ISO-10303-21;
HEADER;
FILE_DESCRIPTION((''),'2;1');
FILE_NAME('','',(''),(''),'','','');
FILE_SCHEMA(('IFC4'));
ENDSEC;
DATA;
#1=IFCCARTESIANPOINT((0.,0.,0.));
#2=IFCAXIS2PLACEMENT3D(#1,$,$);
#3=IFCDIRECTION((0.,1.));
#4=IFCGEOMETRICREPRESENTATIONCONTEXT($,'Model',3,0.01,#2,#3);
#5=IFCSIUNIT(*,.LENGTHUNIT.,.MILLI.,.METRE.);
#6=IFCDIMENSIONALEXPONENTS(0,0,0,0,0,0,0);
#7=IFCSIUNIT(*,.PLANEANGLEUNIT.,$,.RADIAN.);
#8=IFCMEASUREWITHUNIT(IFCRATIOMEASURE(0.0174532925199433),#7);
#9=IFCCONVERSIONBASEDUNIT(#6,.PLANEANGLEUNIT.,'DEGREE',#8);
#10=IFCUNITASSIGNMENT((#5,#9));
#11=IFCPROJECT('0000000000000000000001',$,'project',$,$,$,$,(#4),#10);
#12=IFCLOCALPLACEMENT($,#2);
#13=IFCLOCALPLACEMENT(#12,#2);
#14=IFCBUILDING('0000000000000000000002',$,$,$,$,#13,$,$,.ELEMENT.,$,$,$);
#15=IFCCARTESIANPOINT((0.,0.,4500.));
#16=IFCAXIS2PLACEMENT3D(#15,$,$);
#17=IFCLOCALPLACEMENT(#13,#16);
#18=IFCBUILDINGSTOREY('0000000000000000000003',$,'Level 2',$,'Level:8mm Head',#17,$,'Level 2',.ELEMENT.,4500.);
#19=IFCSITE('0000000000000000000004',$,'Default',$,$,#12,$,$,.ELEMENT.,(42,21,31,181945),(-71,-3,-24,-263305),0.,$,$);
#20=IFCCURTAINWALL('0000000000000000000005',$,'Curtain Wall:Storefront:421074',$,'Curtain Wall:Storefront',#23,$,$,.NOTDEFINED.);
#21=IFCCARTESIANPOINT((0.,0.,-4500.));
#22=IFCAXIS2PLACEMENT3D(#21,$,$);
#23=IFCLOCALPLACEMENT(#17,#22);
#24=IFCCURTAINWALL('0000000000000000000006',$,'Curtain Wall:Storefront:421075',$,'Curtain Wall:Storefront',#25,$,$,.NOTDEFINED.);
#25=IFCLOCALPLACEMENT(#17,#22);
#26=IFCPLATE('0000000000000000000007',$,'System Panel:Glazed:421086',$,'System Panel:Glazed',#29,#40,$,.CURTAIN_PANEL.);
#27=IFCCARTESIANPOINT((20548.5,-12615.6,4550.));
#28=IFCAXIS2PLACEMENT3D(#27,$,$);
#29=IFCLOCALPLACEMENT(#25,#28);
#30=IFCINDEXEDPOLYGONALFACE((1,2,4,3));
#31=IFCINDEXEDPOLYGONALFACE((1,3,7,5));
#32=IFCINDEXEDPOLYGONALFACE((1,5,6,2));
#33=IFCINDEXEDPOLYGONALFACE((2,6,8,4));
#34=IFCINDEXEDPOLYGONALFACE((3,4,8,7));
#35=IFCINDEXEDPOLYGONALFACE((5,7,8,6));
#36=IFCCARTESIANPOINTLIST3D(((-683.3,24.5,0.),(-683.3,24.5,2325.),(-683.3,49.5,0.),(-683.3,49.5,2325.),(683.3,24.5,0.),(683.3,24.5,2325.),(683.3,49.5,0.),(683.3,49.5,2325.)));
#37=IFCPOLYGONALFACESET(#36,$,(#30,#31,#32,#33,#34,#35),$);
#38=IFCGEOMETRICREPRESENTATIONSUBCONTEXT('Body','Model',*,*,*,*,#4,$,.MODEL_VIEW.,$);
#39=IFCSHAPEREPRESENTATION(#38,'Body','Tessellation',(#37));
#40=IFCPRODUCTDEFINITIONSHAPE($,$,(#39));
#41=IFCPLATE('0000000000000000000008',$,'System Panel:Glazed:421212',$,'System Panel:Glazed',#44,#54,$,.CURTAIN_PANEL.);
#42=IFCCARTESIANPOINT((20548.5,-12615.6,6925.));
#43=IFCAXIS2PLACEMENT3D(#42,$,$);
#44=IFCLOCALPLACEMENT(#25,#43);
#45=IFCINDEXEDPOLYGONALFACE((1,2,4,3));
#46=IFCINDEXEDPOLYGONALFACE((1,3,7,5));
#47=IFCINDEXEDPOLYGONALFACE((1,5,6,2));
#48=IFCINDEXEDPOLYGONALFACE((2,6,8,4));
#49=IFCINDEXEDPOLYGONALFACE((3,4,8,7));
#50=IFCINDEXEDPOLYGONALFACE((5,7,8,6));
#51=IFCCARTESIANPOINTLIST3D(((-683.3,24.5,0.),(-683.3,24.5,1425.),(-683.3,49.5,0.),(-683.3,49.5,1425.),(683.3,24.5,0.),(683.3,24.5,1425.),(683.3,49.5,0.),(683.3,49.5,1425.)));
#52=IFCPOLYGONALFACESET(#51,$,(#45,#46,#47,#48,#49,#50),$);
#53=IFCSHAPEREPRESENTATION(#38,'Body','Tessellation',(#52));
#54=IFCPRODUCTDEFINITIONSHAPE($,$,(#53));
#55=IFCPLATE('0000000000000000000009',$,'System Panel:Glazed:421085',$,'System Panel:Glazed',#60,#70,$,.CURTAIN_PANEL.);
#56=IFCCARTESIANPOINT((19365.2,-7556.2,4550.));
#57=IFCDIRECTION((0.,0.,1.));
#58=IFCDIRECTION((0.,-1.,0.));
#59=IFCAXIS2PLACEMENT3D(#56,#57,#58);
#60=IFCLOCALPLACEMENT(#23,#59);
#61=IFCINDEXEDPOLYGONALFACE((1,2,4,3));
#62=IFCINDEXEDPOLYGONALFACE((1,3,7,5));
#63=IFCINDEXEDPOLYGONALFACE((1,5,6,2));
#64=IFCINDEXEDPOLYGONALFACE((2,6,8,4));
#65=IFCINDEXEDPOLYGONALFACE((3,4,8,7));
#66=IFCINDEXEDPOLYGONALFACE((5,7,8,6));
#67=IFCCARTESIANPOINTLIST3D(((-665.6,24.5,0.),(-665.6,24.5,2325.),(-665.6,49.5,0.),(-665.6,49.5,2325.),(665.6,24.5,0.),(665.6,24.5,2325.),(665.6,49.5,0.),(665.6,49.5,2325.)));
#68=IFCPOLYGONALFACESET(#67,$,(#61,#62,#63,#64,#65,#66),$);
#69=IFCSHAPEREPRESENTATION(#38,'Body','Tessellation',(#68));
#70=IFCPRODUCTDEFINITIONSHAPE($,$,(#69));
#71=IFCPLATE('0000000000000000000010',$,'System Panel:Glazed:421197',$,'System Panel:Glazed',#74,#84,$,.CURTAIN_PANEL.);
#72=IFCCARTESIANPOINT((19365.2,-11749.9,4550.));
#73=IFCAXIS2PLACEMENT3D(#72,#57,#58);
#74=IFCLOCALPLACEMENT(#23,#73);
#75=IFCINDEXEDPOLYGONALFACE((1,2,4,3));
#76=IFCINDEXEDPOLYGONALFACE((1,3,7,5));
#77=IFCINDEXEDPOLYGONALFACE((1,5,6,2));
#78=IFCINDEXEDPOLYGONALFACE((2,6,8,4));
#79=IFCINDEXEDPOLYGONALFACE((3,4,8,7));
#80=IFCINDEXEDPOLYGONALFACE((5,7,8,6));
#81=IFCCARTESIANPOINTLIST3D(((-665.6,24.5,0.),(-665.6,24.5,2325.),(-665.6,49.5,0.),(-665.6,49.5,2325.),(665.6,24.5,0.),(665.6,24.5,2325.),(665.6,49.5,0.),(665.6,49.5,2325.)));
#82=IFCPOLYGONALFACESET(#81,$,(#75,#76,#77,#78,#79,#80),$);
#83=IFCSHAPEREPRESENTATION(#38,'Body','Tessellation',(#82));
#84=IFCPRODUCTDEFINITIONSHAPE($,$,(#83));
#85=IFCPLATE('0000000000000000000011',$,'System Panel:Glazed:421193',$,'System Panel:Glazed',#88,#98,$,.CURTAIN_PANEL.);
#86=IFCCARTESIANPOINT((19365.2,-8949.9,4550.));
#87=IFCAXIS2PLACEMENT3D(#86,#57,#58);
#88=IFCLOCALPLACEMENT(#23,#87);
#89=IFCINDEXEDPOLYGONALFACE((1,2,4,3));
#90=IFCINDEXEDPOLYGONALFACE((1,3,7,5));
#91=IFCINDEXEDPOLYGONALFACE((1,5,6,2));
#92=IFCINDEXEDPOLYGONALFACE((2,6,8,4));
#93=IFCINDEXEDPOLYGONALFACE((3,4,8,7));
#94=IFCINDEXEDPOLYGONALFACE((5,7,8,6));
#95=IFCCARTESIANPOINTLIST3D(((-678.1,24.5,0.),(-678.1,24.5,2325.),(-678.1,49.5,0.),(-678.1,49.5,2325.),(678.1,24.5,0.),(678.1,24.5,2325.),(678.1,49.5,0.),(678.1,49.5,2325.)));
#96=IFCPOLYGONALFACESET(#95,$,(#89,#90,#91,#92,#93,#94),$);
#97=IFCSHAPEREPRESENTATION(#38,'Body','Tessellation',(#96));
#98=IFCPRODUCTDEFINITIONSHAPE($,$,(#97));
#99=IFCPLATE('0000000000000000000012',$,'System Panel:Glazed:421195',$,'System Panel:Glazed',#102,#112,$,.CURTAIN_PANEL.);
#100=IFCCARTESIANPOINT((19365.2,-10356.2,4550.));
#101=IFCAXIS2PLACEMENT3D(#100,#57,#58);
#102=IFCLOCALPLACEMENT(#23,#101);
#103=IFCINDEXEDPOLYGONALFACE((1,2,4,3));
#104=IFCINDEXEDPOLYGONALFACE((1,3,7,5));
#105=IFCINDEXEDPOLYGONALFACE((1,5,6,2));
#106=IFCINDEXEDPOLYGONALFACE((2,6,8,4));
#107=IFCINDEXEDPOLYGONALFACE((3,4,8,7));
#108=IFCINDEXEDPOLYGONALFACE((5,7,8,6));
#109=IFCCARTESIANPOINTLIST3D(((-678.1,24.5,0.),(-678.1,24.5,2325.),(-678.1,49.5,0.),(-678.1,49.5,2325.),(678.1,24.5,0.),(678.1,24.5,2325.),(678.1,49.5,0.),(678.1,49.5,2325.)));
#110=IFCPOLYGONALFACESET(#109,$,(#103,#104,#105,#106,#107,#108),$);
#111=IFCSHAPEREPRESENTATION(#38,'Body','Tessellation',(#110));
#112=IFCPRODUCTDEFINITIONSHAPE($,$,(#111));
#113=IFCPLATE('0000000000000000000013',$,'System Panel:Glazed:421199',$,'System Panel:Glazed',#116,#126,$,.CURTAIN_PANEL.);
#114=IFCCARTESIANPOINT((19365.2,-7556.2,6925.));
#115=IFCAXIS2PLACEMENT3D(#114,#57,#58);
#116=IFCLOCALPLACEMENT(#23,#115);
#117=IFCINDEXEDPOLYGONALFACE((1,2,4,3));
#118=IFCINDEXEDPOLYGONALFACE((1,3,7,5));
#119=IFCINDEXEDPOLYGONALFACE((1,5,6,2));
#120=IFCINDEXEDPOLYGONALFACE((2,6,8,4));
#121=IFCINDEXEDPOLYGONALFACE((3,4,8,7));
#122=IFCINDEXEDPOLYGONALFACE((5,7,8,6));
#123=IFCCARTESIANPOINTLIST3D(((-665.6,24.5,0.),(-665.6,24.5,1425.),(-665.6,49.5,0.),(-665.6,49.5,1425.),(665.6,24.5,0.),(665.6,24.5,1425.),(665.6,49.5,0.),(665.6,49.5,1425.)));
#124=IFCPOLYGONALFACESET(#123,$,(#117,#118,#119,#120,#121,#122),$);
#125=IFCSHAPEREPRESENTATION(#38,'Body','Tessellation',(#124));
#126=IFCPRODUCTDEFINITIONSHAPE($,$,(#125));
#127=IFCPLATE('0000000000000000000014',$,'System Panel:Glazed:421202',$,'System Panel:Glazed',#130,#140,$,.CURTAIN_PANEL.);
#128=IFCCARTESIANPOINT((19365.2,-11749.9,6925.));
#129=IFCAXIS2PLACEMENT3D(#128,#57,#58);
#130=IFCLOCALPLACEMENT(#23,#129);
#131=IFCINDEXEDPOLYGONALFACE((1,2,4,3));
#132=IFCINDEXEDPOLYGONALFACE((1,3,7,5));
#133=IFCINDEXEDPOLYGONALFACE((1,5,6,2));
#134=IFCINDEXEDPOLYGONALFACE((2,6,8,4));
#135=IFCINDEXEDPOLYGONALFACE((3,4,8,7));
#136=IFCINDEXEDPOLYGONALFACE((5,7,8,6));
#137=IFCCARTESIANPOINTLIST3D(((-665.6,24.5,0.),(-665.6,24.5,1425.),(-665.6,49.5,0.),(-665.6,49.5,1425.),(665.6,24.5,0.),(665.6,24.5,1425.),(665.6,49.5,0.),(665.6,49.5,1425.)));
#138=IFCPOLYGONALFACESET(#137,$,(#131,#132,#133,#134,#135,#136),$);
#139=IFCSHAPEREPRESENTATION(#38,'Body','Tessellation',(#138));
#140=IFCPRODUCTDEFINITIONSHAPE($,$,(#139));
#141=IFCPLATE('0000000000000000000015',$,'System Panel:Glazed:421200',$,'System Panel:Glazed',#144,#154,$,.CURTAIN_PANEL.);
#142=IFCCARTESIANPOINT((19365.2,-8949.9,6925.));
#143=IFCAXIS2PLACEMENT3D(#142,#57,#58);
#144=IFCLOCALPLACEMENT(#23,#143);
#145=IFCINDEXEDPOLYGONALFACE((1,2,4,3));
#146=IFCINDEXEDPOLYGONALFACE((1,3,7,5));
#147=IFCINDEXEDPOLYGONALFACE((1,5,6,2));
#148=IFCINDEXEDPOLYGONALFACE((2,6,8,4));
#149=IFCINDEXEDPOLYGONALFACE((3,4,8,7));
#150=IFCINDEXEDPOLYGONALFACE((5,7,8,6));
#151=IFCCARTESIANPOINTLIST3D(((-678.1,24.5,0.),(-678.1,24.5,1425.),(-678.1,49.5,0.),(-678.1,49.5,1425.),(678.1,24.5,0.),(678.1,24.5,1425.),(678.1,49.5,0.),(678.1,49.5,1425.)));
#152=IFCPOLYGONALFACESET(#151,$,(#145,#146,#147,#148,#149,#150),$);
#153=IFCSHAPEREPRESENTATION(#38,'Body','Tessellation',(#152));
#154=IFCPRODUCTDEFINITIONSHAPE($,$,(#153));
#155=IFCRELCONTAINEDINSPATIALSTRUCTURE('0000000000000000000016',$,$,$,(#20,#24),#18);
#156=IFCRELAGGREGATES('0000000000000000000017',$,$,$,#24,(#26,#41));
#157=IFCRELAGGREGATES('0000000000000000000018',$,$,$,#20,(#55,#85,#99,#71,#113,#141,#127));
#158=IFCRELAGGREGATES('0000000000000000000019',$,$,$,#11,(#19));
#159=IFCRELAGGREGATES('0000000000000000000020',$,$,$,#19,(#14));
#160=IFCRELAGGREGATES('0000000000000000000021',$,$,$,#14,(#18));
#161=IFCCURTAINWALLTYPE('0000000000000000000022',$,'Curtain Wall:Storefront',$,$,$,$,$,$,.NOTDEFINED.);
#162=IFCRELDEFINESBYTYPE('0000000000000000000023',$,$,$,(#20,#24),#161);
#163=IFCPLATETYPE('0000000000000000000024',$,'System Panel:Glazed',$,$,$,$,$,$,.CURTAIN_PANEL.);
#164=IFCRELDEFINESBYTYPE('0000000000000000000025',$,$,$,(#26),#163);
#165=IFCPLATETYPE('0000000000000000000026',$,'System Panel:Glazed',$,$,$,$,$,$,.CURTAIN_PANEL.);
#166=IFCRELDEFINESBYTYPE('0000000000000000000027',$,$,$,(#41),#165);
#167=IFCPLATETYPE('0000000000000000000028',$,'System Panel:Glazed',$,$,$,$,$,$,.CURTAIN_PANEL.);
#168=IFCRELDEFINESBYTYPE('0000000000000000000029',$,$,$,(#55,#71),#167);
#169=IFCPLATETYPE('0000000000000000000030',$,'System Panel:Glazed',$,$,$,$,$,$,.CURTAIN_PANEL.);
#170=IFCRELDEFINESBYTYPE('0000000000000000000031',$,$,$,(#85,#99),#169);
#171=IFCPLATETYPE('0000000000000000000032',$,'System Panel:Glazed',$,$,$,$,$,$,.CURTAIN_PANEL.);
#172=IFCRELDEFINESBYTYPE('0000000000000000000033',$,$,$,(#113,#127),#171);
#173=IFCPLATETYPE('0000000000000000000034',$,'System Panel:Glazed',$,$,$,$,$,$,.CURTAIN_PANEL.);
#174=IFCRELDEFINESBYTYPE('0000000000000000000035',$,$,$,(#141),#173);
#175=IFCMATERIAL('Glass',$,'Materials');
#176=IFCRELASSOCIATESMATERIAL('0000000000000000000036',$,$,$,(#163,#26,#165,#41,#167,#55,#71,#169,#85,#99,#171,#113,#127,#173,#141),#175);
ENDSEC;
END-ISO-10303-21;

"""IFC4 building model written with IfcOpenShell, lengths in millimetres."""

from ifc_helpers import new_model, entity, si_unit, converted_unit, direction, frame, origin, place, context, subcontext, project, spatial, indexed_curve, outline, extrude, shape, source, transform, mapped, material, type_object, type_shapes, element, aggregate, save


model = new_model("IFC4")

# Units and contexts
model_context = context("Model", 3, precision=0.01, world=origin(), true_north=direction((0.0, 1.0)))
body_context = subcontext(model_context, "Body", "Model", "MODEL_VIEW")
footprint_context = subcontext(model_context, "FootPrint", "Model", "MODEL_VIEW")
ifc_project = project(units=[si_unit("LENGTHUNIT", "METRE", prefix="MILLI"), converted_unit("PLANEANGLEUNIT", "DEGREE", entity("IfcRatioMeasure", 0.0174532925199433), si_unit("PLANEANGLEUNIT", "RADIAN"), dimensions=[0, 0, 0, 0, 0, 0, 0])], contexts=[model_context])

# Site, building, storey
site_placement = place(None, origin())
site = spatial("IfcSite", under=ifc_project, at=site_placement, Name="Default", CompositionType="ELEMENT", RefLatitude=(42, 21, 31, 181945), RefLongitude=(-71, -3, -24, -263305), RefElevation=0.0)
building_placement = place(site_placement, origin())
building = spatial("IfcBuilding", under=site, at=building_placement, CompositionType="ELEMENT")
storey_placement = place(building_placement, frame((0.0, 0.0, 4500.0)))
storey = spatial("IfcBuildingStorey", under=building, at=storey_placement, Name="Level 2", ObjectType="Level:8mm Head", LongName="Level 2", CompositionType="ELEMENT", Elevation=4500.0)

# Curtain wall
curtain_wall_type_1 = type_object("IfcCurtainWallType", Name="Curtain Wall:Storefront", PredefinedType="NOTDEFINED")
curtain_wall_1_placement = place(storey_placement, frame((0.0, 0.0, -4500.0)))
curtain_wall_1 = element("IfcCurtainWall", 1, at=curtain_wall_1_placement, inside=storey, type_object=curtain_wall_type_1, Name="Curtain Wall:Storefront:421074", ObjectType="Curtain Wall:Storefront", PredefinedType="NOTDEFINED")

# Curtain wall
curtain_wall_2_placement = place(storey_placement, frame((0.0, 0.0, -4500.0)))
curtain_wall_2 = element("IfcCurtainWall", 2, at=curtain_wall_2_placement, inside=storey, type_object=curtain_wall_type_1, Name="Curtain Wall:Storefront:421075", ObjectType="Curtain Wall:Storefront", PredefinedType="NOTDEFINED")

# Plates
ifc_material_1 = material(Name="Glass", Category="Materials")
plate_type_1 = type_object("IfcPlateType", Name="System Panel:Glazed", PredefinedType="CURTAIN_PANEL", material=ifc_material_1)
shared_shape_1 = source(origin(), body_context, "Body", "SweptSolid", [
    extrude(outline(indexed_curve([(-12.5, -683.3), (12.5, -683.3), (12.5, 683.3), (-12.5, 683.3), (-12.5, -683.3)], self_intersect=False)), frame((0.0, 37.0, 0.0), z_axis=(0.0, 0.0, 1.0), x_axis=(0.0, 1.0, 0.0)), (0.0, 0.0, 1.0), 2325.0),
])
shared_shape_2 = source(origin(), footprint_context, "FootPrint", "Curve2D", [
    entity("IfcIndexedPolyCurve", entity("IfcCartesianPointList2D", [[683.3, 24.5], [683.3, 49.5], [-683.3, 49.5], [-683.3, 24.5], [683.3, 24.5]]), None, False),
])
type_shapes(plate_type_1, [shared_shape_1, shared_shape_2])
plate_1_placement = place(curtain_wall_2_placement, frame((20548.5, -12615.6, 4550.0)))
plate_1 = element("IfcPlate", 3, at=plate_1_placement, type_object=plate_type_1, material=ifc_material_1, Name="System Panel:Glazed:421086", ObjectType="System Panel:Glazed", PredefinedType="CURTAIN_PANEL", shapes=[
    shape(body_context, "Body", "MappedRepresentation", [mapped(shared_shape_1, transform((0.0, 0.0, 0.0), scale=1.0))]),
    shape(body_context, "Body", "MappedRepresentation", [mapped(shared_shape_2, transform((0.0, 0.0, 0.0), scale=1.0))]),
])
plate_type_2 = type_object("IfcPlateType", Name="System Panel:Glazed", PredefinedType="CURTAIN_PANEL", material=ifc_material_1)
shared_shape_3 = source(origin(), body_context, "Body", "SweptSolid", [
    extrude(outline(indexed_curve([(-12.5, -683.3), (12.5, -683.3), (12.5, 683.3), (-12.5, 683.3), (-12.5, -683.3)], self_intersect=False)), frame((0.0, 37.0, 0.0), z_axis=(0.0, 0.0, 1.0), x_axis=(0.0, 1.0, 0.0)), (0.0, 0.0, 1.0), 1425.0),
])
shared_shape_4 = source(origin(), footprint_context, "FootPrint", "Curve2D", [
    entity("IfcIndexedPolyCurve", entity("IfcCartesianPointList2D", [[683.3, 24.5], [683.3, 49.5], [-683.3, 49.5], [-683.3, 24.5], [683.3, 24.5]]), None, False),
])
type_shapes(plate_type_2, [shared_shape_3, shared_shape_4])
plate_2_placement = place(curtain_wall_2_placement, frame((20548.5, -12615.6, 6925.0)))
plate_2 = element("IfcPlate", 4, at=plate_2_placement, type_object=plate_type_2, material=ifc_material_1, Name="System Panel:Glazed:421212", ObjectType="System Panel:Glazed", PredefinedType="CURTAIN_PANEL", shapes=[
    shape(body_context, "Body", "MappedRepresentation", [mapped(shared_shape_3, transform((0.0, 0.0, 0.0), scale=1.0))]),
    shape(body_context, "Body", "MappedRepresentation", [mapped(shared_shape_4, transform((0.0, 0.0, 0.0), scale=1.0))]),
])
aggregate(curtain_wall_2, [plate_1, plate_2])
plate_type_3 = type_object("IfcPlateType", Name="System Panel:Glazed", PredefinedType="CURTAIN_PANEL", material=ifc_material_1)
shared_shape_5 = source(origin(), body_context, "Body", "SweptSolid", [
    extrude(outline(indexed_curve([(-12.5, -665.6), (12.5, -665.6), (12.5, 665.6), (-12.5, 665.6), (-12.5, -665.6)], self_intersect=False)), frame((0.0, 37.0, 0.0), z_axis=(0.0, 0.0, 1.0), x_axis=(0.0, 1.0, 0.0)), (0.0, 0.0, 1.0), 2325.0),
])
shared_shape_6 = source(origin(), footprint_context, "FootPrint", "Curve2D", [
    entity("IfcIndexedPolyCurve", entity("IfcCartesianPointList2D", [[665.6, 24.5], [665.6, 49.5], [-665.6, 49.5], [-665.6, 24.5], [665.6, 24.5]]), None, False),
])
type_shapes(plate_type_3, [shared_shape_5, shared_shape_6])
plate_3_placement = place(curtain_wall_1_placement, frame((19365.2, -7556.2, 4550.0), z_axis=(0.0, 0.0, 1.0), x_axis=(0.0, -1.0, 0.0)))
plate_3 = element("IfcPlate", 5, at=plate_3_placement, type_object=plate_type_3, material=ifc_material_1, Name="System Panel:Glazed:421085", ObjectType="System Panel:Glazed", PredefinedType="CURTAIN_PANEL", shapes=[
    shape(body_context, "Body", "MappedRepresentation", [mapped(shared_shape_5, transform((0.0, 0.0, 0.0), scale=1.0))]),
    shape(body_context, "Body", "MappedRepresentation", [mapped(shared_shape_6, transform((0.0, 0.0, 0.0), scale=1.0))]),
])
plate_4_placement = place(curtain_wall_1_placement, frame((19365.2, -11749.9, 4550.0), z_axis=(0.0, 0.0, 1.0), x_axis=(0.0, -1.0, 0.0)))
plate_4 = element("IfcPlate", 6, at=plate_4_placement, type_object=plate_type_3, material=ifc_material_1, Name="System Panel:Glazed:421197", ObjectType="System Panel:Glazed", PredefinedType="CURTAIN_PANEL", shapes=[
    shape(body_context, "Body", "MappedRepresentation", [mapped(shared_shape_5, transform((0.0, 0.0, 0.0), scale=1.0))]),
    shape(body_context, "Body", "MappedRepresentation", [mapped(shared_shape_6, transform((0.0, 0.0, 0.0), scale=1.0))]),
])
plate_type_4 = type_object("IfcPlateType", Name="System Panel:Glazed", PredefinedType="CURTAIN_PANEL", material=ifc_material_1)
shared_shape_7 = source(origin(), body_context, "Body", "SweptSolid", [
    extrude(outline(indexed_curve([(-12.5, -678.1), (12.5, -678.1), (12.5, 678.1), (-12.5, 678.1), (-12.5, -678.1)], self_intersect=False)), frame((0.0, 37.0, 0.0), z_axis=(0.0, 0.0, 1.0), x_axis=(0.0, 1.0, 0.0)), (0.0, 0.0, 1.0), 2325.0),
])
shared_shape_8 = source(origin(), footprint_context, "FootPrint", "Curve2D", [
    entity("IfcIndexedPolyCurve", entity("IfcCartesianPointList2D", [[678.1, 24.5], [678.1, 49.5], [-678.1, 49.5], [-678.1, 24.5], [678.1, 24.5]]), None, False),
])
type_shapes(plate_type_4, [shared_shape_7, shared_shape_8])
plate_5_placement = place(curtain_wall_1_placement, frame((19365.2, -8949.9, 4550.0), z_axis=(0.0, 0.0, 1.0), x_axis=(0.0, -1.0, 0.0)))
plate_5 = element("IfcPlate", 7, at=plate_5_placement, type_object=plate_type_4, material=ifc_material_1, Name="System Panel:Glazed:421193", ObjectType="System Panel:Glazed", PredefinedType="CURTAIN_PANEL", shapes=[
    shape(body_context, "Body", "MappedRepresentation", [mapped(shared_shape_7, transform((0.0, 0.0, 0.0), scale=1.0))]),
    shape(body_context, "Body", "MappedRepresentation", [mapped(shared_shape_8, transform((0.0, 0.0, 0.0), scale=1.0))]),
])
plate_6_placement = place(curtain_wall_1_placement, frame((19365.2, -10356.2, 4550.0), z_axis=(0.0, 0.0, 1.0), x_axis=(0.0, -1.0, 0.0)))
plate_6 = element("IfcPlate", 8, at=plate_6_placement, type_object=plate_type_4, material=ifc_material_1, Name="System Panel:Glazed:421195", ObjectType="System Panel:Glazed", PredefinedType="CURTAIN_PANEL", shapes=[
    shape(body_context, "Body", "MappedRepresentation", [mapped(shared_shape_7, transform((0.0, 0.0, 0.0), scale=1.0))]),
    shape(body_context, "Body", "MappedRepresentation", [mapped(shared_shape_8, transform((0.0, 0.0, 0.0), scale=1.0))]),
])
plate_type_5 = type_object("IfcPlateType", Name="System Panel:Glazed", PredefinedType="CURTAIN_PANEL", material=ifc_material_1)
shared_shape_9 = source(origin(), body_context, "Body", "SweptSolid", [
    extrude(outline(indexed_curve([(-12.5, -665.6), (12.5, -665.6), (12.5, 665.6), (-12.5, 665.6), (-12.5, -665.6)], self_intersect=False)), frame((0.0, 37.0, 0.0), z_axis=(0.0, 0.0, 1.0), x_axis=(0.0, 1.0, 0.0)), (0.0, 0.0, 1.0), 1425.0),
])
shared_shape_10 = source(origin(), footprint_context, "FootPrint", "Curve2D", [
    entity("IfcIndexedPolyCurve", entity("IfcCartesianPointList2D", [[665.6, 24.5], [665.6, 49.5], [-665.6, 49.5], [-665.6, 24.5], [665.6, 24.5]]), None, False),
])
type_shapes(plate_type_5, [shared_shape_9, shared_shape_10])
plate_7_placement = place(curtain_wall_1_placement, frame((19365.2, -7556.2, 6925.0), z_axis=(0.0, 0.0, 1.0), x_axis=(0.0, -1.0, 0.0)))
plate_7 = element("IfcPlate", 9, at=plate_7_placement, type_object=plate_type_5, material=ifc_material_1, Name="System Panel:Glazed:421199", ObjectType="System Panel:Glazed", PredefinedType="CURTAIN_PANEL", shapes=[
    shape(body_context, "Body", "MappedRepresentation", [mapped(shared_shape_9, transform((0.0, 0.0, 0.0), scale=1.0))]),
    shape(body_context, "Body", "MappedRepresentation", [mapped(shared_shape_10, transform((0.0, 0.0, 0.0), scale=1.0))]),
])
plate_8_placement = place(curtain_wall_1_placement, frame((19365.2, -11749.9, 6925.0), z_axis=(0.0, 0.0, 1.0), x_axis=(0.0, -1.0, 0.0)))
plate_8 = element("IfcPlate", 10, at=plate_8_placement, type_object=plate_type_5, material=ifc_material_1, Name="System Panel:Glazed:421202", ObjectType="System Panel:Glazed", PredefinedType="CURTAIN_PANEL", shapes=[
    shape(body_context, "Body", "MappedRepresentation", [mapped(shared_shape_9, transform((0.0, 0.0, 0.0), scale=1.0))]),
    shape(body_context, "Body", "MappedRepresentation", [mapped(shared_shape_10, transform((0.0, 0.0, 0.0), scale=1.0))]),
])
plate_type_6 = type_object("IfcPlateType", Name="System Panel:Glazed", PredefinedType="CURTAIN_PANEL", material=ifc_material_1)
shared_shape_11 = source(origin(), body_context, "Body", "SweptSolid", [
    extrude(outline(indexed_curve([(-12.5, -678.1), (12.5, -678.1), (12.5, 678.1), (-12.5, 678.1), (-12.5, -678.1)], self_intersect=False)), frame((0.0, 37.0, 0.0), z_axis=(0.0, 0.0, 1.0), x_axis=(0.0, 1.0, 0.0)), (0.0, 0.0, 1.0), 1425.0),
])
shared_shape_12 = source(origin(), footprint_context, "FootPrint", "Curve2D", [
    entity("IfcIndexedPolyCurve", entity("IfcCartesianPointList2D", [[678.1, 24.5], [678.1, 49.5], [-678.1, 49.5], [-678.1, 24.5], [678.1, 24.5]]), None, False),
])
type_shapes(plate_type_6, [shared_shape_11, shared_shape_12])
plate_9_placement = place(curtain_wall_1_placement, frame((19365.2, -8949.9, 6925.0), z_axis=(0.0, 0.0, 1.0), x_axis=(0.0, -1.0, 0.0)))
plate_9 = element("IfcPlate", 11, at=plate_9_placement, type_object=plate_type_6, material=ifc_material_1, Name="System Panel:Glazed:421200", ObjectType="System Panel:Glazed", PredefinedType="CURTAIN_PANEL", shapes=[
    shape(body_context, "Body", "MappedRepresentation", [mapped(shared_shape_11, transform((0.0, 0.0, 0.0), scale=1.0))]),
    shape(body_context, "Body", "MappedRepresentation", [mapped(shared_shape_12, transform((0.0, 0.0, 0.0), scale=1.0))]),
])
aggregate(curtain_wall_1, [plate_3, plate_5, plate_6, plate_4, plate_7, plate_9, plate_8])

save(model, "model.ifc")
